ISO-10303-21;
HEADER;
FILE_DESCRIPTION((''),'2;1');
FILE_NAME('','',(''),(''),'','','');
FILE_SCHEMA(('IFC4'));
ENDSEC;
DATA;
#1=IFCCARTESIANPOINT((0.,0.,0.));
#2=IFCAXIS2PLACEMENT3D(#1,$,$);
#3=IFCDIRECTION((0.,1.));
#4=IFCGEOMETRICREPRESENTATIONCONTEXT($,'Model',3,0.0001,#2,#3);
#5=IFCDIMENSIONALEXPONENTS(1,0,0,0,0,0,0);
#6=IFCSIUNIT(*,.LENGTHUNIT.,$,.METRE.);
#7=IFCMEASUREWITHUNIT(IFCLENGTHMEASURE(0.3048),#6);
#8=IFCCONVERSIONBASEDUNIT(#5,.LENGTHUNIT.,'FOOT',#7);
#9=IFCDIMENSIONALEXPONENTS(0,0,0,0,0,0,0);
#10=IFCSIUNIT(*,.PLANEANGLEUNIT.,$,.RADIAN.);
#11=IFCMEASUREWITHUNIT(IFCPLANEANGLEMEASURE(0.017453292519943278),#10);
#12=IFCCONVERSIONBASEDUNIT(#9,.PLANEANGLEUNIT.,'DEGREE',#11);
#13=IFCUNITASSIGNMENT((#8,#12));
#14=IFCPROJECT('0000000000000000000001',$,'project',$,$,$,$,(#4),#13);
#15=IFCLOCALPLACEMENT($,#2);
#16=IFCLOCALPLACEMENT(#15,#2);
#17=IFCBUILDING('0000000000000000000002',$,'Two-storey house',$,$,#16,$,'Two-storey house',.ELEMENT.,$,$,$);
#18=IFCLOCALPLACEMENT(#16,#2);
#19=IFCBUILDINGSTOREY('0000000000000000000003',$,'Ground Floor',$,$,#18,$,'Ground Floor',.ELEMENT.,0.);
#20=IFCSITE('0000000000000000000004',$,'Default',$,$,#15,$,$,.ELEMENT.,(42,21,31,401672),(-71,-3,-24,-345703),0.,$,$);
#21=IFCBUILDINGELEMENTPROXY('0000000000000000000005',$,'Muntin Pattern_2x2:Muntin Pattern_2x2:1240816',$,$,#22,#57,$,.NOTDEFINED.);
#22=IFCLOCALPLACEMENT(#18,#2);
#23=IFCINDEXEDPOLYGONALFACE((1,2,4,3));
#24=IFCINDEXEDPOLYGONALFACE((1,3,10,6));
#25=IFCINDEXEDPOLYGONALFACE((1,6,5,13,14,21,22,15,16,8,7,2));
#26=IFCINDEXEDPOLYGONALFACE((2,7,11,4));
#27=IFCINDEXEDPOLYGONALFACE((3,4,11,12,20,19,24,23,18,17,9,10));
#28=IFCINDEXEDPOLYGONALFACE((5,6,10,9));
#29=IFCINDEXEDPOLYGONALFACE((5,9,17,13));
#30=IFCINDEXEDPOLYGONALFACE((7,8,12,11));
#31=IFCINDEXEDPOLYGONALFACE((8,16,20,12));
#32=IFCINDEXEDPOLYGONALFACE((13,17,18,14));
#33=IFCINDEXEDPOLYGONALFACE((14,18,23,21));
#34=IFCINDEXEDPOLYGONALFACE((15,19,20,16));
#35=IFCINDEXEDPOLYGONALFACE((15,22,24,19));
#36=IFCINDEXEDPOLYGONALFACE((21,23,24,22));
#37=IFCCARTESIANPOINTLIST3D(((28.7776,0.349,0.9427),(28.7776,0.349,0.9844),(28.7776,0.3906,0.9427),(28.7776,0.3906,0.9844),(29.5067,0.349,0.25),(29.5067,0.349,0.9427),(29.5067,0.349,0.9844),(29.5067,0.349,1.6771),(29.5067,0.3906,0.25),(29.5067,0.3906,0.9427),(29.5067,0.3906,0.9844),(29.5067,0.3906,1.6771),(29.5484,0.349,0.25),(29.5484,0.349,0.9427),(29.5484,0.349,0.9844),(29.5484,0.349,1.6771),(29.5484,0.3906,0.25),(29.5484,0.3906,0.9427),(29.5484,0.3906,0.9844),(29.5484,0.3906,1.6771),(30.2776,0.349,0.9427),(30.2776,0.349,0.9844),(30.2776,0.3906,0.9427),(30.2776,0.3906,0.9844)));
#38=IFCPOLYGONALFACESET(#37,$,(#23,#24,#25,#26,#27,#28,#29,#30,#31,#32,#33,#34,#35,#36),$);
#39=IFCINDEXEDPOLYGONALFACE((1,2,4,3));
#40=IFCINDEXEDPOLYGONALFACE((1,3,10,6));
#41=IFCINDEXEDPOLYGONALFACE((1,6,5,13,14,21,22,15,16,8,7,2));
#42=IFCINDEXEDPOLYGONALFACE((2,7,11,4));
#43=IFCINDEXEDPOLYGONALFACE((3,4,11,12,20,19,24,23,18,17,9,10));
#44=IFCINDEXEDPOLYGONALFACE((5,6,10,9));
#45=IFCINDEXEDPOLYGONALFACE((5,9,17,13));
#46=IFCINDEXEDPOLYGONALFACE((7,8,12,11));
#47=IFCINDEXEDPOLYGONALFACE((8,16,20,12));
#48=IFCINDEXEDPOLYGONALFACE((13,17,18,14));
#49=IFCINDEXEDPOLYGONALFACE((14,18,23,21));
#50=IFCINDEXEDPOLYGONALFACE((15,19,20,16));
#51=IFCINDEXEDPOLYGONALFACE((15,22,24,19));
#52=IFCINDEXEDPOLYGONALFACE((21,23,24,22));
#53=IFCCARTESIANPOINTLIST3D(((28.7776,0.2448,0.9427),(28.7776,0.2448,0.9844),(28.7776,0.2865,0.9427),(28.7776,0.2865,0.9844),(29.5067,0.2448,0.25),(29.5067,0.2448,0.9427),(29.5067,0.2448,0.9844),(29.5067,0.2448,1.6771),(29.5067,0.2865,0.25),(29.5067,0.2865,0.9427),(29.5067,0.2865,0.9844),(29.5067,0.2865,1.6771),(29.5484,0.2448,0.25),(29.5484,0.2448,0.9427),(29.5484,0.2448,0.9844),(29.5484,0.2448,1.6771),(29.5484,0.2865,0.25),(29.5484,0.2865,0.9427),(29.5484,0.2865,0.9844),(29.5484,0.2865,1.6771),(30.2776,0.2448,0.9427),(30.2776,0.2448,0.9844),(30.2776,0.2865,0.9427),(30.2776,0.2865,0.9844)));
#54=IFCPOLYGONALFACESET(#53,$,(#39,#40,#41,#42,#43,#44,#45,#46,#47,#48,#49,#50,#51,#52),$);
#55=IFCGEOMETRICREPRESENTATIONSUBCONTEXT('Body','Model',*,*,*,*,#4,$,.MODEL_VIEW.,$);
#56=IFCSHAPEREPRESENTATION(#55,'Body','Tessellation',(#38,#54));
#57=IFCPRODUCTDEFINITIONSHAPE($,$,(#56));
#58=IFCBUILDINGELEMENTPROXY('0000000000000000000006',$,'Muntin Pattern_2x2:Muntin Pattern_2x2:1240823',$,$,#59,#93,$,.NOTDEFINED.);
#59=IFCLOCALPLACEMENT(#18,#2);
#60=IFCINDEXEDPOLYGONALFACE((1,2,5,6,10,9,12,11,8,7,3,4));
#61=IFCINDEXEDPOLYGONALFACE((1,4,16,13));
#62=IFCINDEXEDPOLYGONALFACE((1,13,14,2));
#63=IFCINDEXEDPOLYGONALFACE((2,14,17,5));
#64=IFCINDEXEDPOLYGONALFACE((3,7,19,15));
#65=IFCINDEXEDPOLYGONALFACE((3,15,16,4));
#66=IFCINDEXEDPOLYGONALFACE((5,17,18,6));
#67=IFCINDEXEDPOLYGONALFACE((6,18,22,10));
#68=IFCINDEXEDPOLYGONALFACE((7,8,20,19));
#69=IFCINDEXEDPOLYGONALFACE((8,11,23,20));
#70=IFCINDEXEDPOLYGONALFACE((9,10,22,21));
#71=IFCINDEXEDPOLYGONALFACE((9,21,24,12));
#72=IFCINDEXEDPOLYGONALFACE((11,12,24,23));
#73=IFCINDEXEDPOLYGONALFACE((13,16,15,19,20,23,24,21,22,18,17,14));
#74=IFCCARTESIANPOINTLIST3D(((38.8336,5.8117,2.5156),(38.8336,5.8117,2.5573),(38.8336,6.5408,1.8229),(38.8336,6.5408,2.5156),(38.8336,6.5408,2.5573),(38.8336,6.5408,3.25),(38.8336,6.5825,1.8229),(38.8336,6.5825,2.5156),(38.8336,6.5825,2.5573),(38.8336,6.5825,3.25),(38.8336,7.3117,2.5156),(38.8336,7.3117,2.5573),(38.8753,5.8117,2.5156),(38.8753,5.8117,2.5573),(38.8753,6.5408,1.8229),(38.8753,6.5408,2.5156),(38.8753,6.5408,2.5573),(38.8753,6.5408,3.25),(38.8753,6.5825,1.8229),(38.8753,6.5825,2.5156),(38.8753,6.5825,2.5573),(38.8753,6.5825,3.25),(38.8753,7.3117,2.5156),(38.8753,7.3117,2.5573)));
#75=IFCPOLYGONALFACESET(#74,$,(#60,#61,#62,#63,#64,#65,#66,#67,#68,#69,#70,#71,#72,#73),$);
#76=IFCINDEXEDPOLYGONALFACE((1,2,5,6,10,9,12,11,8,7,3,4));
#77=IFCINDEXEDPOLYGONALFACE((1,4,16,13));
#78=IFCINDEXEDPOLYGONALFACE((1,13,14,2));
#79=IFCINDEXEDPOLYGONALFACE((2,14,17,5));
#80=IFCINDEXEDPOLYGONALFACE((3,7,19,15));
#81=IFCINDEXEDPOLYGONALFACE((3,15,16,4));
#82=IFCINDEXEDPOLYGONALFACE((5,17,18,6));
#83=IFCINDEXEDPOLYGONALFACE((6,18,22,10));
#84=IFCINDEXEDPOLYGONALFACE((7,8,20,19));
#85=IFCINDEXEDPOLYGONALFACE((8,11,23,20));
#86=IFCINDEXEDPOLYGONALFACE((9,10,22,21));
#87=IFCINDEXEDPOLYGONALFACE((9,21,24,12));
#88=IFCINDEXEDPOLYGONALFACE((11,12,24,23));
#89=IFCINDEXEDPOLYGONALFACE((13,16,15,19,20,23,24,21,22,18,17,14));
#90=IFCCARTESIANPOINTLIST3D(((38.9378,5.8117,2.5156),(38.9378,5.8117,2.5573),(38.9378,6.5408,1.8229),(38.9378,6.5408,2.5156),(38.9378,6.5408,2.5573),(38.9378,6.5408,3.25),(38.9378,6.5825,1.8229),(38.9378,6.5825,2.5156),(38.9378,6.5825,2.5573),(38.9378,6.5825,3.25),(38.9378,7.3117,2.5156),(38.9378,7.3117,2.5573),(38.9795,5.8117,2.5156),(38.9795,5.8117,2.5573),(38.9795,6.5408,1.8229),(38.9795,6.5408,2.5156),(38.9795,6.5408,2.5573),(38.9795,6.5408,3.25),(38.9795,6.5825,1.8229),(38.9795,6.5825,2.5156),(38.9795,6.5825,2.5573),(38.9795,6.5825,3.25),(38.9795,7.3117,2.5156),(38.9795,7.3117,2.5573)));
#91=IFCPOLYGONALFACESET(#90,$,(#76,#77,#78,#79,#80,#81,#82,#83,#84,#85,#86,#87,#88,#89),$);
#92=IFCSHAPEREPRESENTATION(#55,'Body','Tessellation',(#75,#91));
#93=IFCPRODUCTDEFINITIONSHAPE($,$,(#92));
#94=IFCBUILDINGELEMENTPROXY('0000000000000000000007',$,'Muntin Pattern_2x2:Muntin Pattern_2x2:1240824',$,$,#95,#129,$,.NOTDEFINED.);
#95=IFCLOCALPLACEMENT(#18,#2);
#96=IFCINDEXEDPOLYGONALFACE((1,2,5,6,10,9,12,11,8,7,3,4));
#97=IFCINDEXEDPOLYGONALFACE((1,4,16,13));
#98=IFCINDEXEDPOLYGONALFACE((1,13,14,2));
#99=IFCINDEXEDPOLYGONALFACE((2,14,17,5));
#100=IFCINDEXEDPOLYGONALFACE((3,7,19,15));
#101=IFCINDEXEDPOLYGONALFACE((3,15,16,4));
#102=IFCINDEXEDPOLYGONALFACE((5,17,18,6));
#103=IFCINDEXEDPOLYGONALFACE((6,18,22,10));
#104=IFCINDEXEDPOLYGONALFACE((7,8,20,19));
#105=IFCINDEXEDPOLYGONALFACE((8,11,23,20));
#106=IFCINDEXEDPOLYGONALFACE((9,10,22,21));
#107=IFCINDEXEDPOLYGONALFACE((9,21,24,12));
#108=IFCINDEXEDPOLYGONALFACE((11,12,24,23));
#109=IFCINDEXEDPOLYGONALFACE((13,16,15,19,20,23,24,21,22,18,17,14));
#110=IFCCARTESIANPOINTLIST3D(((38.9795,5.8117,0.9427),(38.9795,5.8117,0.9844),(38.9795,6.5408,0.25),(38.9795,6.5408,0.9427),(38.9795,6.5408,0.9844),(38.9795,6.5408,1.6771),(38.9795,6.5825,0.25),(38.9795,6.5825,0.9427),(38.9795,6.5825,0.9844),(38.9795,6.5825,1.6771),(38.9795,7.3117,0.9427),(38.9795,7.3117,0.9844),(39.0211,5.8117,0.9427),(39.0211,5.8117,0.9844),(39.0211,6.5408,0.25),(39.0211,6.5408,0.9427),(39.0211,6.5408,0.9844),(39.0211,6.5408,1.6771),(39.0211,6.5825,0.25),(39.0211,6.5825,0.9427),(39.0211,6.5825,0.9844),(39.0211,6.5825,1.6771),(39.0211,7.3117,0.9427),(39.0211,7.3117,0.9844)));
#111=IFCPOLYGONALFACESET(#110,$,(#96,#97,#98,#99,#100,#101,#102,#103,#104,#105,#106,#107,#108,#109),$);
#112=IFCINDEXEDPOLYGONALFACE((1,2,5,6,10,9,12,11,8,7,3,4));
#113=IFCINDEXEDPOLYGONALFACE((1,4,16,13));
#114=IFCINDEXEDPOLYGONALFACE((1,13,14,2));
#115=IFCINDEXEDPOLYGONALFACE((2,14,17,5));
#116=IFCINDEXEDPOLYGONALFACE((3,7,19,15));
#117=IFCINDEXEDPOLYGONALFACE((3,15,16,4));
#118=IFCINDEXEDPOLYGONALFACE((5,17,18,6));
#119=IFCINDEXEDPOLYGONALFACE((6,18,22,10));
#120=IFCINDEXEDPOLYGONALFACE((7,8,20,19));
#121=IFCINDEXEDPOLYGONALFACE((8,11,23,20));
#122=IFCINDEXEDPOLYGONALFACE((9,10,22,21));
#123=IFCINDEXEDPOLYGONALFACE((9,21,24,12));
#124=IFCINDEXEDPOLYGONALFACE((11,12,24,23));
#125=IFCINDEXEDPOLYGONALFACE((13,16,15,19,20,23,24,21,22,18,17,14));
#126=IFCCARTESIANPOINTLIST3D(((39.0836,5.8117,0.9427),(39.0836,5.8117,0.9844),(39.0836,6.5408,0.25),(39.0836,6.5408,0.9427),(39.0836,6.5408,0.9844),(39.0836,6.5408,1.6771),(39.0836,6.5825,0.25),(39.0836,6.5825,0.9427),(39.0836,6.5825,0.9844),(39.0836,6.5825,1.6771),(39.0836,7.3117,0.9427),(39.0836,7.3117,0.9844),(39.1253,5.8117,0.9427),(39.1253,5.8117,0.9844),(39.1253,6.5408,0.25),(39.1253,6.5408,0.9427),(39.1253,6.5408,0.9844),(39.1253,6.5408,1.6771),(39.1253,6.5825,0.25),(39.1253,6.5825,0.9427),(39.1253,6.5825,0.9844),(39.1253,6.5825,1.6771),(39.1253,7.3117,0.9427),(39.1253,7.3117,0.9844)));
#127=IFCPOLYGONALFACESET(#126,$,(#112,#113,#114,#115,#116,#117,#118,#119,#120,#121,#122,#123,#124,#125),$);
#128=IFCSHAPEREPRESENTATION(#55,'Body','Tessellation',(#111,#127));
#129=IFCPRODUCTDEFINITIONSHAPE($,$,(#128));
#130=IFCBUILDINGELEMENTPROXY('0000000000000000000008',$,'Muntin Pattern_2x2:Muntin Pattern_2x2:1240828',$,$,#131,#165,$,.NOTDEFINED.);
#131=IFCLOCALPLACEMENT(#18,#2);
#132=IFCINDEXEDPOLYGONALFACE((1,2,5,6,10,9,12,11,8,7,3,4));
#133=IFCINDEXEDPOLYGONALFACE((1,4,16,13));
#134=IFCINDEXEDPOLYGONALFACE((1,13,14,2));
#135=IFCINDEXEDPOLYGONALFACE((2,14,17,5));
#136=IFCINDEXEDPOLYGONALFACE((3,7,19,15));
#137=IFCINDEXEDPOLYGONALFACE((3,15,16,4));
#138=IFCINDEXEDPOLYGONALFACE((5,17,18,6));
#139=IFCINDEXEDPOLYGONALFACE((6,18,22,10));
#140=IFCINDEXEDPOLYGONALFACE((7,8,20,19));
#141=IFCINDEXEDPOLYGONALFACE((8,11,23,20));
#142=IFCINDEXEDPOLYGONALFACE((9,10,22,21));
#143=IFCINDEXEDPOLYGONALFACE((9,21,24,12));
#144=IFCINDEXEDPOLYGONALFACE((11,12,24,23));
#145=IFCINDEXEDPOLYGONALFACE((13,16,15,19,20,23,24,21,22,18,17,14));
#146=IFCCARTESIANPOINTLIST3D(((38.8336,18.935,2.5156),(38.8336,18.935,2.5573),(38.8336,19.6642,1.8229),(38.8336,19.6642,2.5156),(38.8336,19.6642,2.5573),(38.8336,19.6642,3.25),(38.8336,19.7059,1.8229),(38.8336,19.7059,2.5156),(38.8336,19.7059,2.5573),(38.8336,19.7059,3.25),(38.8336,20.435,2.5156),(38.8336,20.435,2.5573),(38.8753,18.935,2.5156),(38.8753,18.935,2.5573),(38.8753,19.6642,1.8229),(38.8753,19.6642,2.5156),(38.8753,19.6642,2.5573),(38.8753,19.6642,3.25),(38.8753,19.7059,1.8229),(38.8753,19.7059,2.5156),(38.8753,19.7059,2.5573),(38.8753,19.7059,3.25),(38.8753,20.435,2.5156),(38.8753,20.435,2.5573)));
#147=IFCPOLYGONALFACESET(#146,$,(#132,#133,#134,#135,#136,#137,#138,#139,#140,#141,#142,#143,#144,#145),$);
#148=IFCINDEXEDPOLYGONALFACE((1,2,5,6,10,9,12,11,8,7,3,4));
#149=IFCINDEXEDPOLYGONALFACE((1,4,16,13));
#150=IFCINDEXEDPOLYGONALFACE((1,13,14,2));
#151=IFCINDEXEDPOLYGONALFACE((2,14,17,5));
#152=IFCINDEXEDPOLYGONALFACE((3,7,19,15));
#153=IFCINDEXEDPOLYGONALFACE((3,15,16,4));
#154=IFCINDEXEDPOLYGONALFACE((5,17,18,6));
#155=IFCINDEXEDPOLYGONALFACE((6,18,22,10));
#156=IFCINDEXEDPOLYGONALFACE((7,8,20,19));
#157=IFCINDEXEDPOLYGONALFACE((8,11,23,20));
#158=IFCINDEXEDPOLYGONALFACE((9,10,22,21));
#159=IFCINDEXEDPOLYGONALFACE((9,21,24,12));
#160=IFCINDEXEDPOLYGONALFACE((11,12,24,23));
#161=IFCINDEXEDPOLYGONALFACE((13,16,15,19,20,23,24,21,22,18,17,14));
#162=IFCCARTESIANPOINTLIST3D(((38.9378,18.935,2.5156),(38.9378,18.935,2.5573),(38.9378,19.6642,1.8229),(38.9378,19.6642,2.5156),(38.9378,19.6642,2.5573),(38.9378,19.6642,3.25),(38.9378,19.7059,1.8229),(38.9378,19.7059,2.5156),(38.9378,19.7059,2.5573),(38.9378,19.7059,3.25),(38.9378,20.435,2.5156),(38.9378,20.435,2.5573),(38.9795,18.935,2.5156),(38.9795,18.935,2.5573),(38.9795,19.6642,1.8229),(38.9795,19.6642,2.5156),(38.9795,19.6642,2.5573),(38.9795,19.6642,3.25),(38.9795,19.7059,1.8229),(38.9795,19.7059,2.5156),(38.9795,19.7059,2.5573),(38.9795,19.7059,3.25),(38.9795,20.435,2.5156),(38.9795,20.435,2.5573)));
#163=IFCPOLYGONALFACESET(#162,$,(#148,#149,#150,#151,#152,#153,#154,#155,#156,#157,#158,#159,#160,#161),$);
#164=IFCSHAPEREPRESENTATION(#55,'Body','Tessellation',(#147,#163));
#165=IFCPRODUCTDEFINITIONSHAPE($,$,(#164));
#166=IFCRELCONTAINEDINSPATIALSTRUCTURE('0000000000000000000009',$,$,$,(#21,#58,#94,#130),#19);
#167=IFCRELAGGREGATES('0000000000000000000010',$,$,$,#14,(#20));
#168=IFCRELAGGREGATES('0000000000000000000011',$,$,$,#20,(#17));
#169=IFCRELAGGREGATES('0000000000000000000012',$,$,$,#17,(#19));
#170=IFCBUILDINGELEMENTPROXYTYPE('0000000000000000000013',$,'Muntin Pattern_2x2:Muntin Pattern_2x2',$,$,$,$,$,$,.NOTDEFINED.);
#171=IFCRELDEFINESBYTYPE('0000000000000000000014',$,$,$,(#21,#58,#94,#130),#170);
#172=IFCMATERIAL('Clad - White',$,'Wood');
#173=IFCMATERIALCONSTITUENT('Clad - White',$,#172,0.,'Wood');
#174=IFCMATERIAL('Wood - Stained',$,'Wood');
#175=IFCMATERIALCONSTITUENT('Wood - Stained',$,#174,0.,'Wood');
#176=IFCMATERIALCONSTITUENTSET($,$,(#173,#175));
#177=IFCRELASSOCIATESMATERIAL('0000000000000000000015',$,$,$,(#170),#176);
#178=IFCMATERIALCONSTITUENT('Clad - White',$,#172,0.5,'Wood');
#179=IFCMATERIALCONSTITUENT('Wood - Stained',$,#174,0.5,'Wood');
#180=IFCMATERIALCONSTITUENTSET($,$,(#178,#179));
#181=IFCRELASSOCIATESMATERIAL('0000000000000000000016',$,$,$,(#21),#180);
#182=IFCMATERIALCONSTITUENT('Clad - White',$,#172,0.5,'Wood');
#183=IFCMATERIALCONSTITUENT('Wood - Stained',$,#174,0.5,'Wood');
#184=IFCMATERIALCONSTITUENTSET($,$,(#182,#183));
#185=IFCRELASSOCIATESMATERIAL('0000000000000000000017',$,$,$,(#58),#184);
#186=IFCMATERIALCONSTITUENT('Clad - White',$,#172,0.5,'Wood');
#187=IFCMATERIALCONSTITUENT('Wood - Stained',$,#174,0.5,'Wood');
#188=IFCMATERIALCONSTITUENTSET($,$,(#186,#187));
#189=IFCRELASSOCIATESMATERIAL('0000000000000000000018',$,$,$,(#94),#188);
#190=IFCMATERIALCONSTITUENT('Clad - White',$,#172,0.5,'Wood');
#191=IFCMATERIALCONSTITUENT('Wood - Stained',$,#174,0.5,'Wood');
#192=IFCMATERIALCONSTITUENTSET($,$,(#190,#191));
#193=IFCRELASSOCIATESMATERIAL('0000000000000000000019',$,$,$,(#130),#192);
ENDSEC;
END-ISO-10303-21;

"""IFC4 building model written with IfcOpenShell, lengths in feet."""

from ifc_helpers import new_model, entity, si_unit, converted_unit, direction, frame, origin, place, context, subcontext, project, spatial, indexed_curve, outline, extrude, source, transform, mapped, material, constituent, constituent_set, type_object, type_shapes, element, save


model = new_model("IFC4")

# Units and contexts
model_context = context("Model", 3, precision=0.0001, world=origin(), true_north=direction((0.0, 1.0)))
body_context = subcontext(model_context, "Body", "Model", "MODEL_VIEW")
ifc_project = project(units=[converted_unit("LENGTHUNIT", "FOOT", entity("IfcLengthMeasure", 0.3048), si_unit("LENGTHUNIT", "METRE"), dimensions=[1, 0, 0, 0, 0, 0, 0]), converted_unit("PLANEANGLEUNIT", "DEGREE", entity("IfcPlaneAngleMeasure", 0.017453292519943278), si_unit("PLANEANGLEUNIT", "RADIAN"), dimensions=[0, 0, 0, 0, 0, 0, 0])], contexts=[model_context])

# Site, building, storey
site_placement = place(None, origin())
site = spatial("IfcSite", under=ifc_project, at=site_placement, Name="Default", CompositionType="ELEMENT", RefLatitude=(42, 21, 31, 401672), RefLongitude=(-71, -3, -24, -345703), RefElevation=0.0)
building_placement = place(site_placement, origin())
building = spatial("IfcBuilding", under=site, at=building_placement, Name="Two-storey house", LongName="Two-storey house", CompositionType="ELEMENT")
storey_placement = place(building_placement, origin())
storey = spatial("IfcBuildingStorey", under=building, at=storey_placement, Name="Ground Floor", LongName="Ground Floor", CompositionType="ELEMENT", Elevation=0.0)

# Shared definitions
ifc_material_1 = material(Name="Wood - Stained", Category="Wood")

# Building element proxies
ifc_material_2 = material(Name="Clad - White", Category="Wood")
ifc_constituent_1 = constituent(ifc_material_2, Name="Clad - White", Category="Wood", fraction=0.5)
ifc_constituent_2 = constituent(ifc_material_1, Name="Wood - Stained", Category="Wood", fraction=0.5)
ifc_constituent_set_1 = constituent_set(constituents=[ifc_constituent_1, ifc_constituent_2])
ifc_constituent_3 = constituent(ifc_material_2, Name="Clad - White", Category="Wood", fraction=0.0)
ifc_constituent_4 = constituent(ifc_material_1, Name="Wood - Stained", Category="Wood", fraction=0.0)
ifc_constituent_set_2 = constituent_set(constituents=[ifc_constituent_3, ifc_constituent_4])
building_element_proxy_type_1 = type_object("IfcBuildingElementProxyType", Name="Muntin Pattern_2x2:Muntin Pattern_2x2", PredefinedType="NOTDEFINED", material=ifc_constituent_set_2)
shared_shape_1 = source(origin(), body_context, "Body", "SweptSolid", [
    extrude(outline(indexed_curve([(0.0208, -0.0208), (0.7135, -0.0208), (0.7135, 0.0208), (0.0208, 0.0208), (0.0208, 0.75), (-0.0208, 0.75), (-0.0208, 0.0208), (-0.7135, 0.0208), (-0.7135, -0.0208), (-0.0208, -0.0208), (-0.0208, -0.75), (0.0208, -0.75), (0.0208, -0.0208)], self_intersect=False)), frame((0.0, 0.0312, 0.7135), z_axis=(0.0, 1.0, 0.0), x_axis=(0.0, 0.0, 1.0)), (0.0, 0.0, 1.0), 0.0417),
    extrude(outline(indexed_curve([(0.0208, -0.0208), (0.7135, -0.0208), (0.7135, 0.0208), (0.0208, 0.0208), (0.0208, 0.75), (-0.0208, 0.75), (-0.0208, 0.0208), (-0.7135, 0.0208), (-0.7135, -0.0208), (-0.0208, -0.0208), (-0.0208, -0.75), (0.0208, -0.75), (0.0208, -0.0208)], self_intersect=False)), frame((0.0, -0.0729, 0.7135), z_axis=(0.0, 1.0, 0.0), x_axis=(0.0, 0.0, 1.0)), (0.0, 0.0, 1.0), 0.0417),
])
type_shapes(building_element_proxy_type_1, [shared_shape_1])
proxy_1_placement = place(storey_placement, frame((29.5276, 0.3177, 0.25)))
element("IfcBuildingElementProxy", 1, at=proxy_1_placement, inside=storey, type_object=building_element_proxy_type_1, material=ifc_constituent_set_1, Name="Muntin Pattern_2x2:Muntin Pattern_2x2:1240816", PredefinedType="NOTDEFINED", context=body_context, shape_type="MappedRepresentation", body=[
    mapped(shared_shape_1, transform((0.0, 0.0, 0.0), scale=1.0)),
])
ifc_constituent_5 = constituent(ifc_material_2, Name="Clad - White", Category="Wood", fraction=0.5)
ifc_constituent_6 = constituent(ifc_material_1, Name="Wood - Stained", Category="Wood", fraction=0.5)
ifc_constituent_set_3 = constituent_set(constituents=[ifc_constituent_5, ifc_constituent_6])
proxy_2_placement = place(storey_placement, frame((38.9065, 6.5617, 1.8229), z_axis=(0.0, 0.0, 1.0), x_axis=(0.0, 1.0, 0.0)))
element("IfcBuildingElementProxy", 2, at=proxy_2_placement, inside=storey, type_object=building_element_proxy_type_1, material=ifc_constituent_set_3, Name="Muntin Pattern_2x2:Muntin Pattern_2x2:1240823", PredefinedType="NOTDEFINED", context=body_context, shape_type="MappedRepresentation", body=[
    mapped(shared_shape_1, transform((0.0, 0.0, 0.0), scale=1.0)),
])
ifc_constituent_7 = constituent(ifc_material_2, Name="Clad - White", Category="Wood", fraction=0.5)
ifc_constituent_8 = constituent(ifc_material_1, Name="Wood - Stained", Category="Wood", fraction=0.5)
ifc_constituent_set_4 = constituent_set(constituents=[ifc_constituent_7, ifc_constituent_8])
proxy_3_placement = place(storey_placement, frame((39.0524, 6.5617, 0.25), z_axis=(0.0, 0.0, 1.0), x_axis=(0.0, 1.0, 0.0)))
element("IfcBuildingElementProxy", 3, at=proxy_3_placement, inside=storey, type_object=building_element_proxy_type_1, material=ifc_constituent_set_4, Name="Muntin Pattern_2x2:Muntin Pattern_2x2:1240824", PredefinedType="NOTDEFINED", context=body_context, shape_type="MappedRepresentation", body=[
    mapped(shared_shape_1, transform((0.0, 0.0, 0.0), scale=1.0)),
])
ifc_constituent_9 = constituent(ifc_material_2, Name="Clad - White", Category="Wood", fraction=0.5)
ifc_constituent_10 = constituent(ifc_material_1, Name="Wood - Stained", Category="Wood", fraction=0.5)
ifc_constituent_set_5 = constituent_set(constituents=[ifc_constituent_9, ifc_constituent_10])
proxy_4_placement = place(storey_placement, frame((38.9065, 19.685, 1.8229), z_axis=(0.0, 0.0, 1.0), x_axis=(0.0, 1.0, 0.0)))
element("IfcBuildingElementProxy", 4, at=proxy_4_placement, inside=storey, type_object=building_element_proxy_type_1, material=ifc_constituent_set_5, Name="Muntin Pattern_2x2:Muntin Pattern_2x2:1240828", PredefinedType="NOTDEFINED", context=body_context, shape_type="MappedRepresentation", body=[
    mapped(shared_shape_1, transform((0.0, 0.0, 0.0), scale=1.0)),
])

save(model, "model.ifc")
